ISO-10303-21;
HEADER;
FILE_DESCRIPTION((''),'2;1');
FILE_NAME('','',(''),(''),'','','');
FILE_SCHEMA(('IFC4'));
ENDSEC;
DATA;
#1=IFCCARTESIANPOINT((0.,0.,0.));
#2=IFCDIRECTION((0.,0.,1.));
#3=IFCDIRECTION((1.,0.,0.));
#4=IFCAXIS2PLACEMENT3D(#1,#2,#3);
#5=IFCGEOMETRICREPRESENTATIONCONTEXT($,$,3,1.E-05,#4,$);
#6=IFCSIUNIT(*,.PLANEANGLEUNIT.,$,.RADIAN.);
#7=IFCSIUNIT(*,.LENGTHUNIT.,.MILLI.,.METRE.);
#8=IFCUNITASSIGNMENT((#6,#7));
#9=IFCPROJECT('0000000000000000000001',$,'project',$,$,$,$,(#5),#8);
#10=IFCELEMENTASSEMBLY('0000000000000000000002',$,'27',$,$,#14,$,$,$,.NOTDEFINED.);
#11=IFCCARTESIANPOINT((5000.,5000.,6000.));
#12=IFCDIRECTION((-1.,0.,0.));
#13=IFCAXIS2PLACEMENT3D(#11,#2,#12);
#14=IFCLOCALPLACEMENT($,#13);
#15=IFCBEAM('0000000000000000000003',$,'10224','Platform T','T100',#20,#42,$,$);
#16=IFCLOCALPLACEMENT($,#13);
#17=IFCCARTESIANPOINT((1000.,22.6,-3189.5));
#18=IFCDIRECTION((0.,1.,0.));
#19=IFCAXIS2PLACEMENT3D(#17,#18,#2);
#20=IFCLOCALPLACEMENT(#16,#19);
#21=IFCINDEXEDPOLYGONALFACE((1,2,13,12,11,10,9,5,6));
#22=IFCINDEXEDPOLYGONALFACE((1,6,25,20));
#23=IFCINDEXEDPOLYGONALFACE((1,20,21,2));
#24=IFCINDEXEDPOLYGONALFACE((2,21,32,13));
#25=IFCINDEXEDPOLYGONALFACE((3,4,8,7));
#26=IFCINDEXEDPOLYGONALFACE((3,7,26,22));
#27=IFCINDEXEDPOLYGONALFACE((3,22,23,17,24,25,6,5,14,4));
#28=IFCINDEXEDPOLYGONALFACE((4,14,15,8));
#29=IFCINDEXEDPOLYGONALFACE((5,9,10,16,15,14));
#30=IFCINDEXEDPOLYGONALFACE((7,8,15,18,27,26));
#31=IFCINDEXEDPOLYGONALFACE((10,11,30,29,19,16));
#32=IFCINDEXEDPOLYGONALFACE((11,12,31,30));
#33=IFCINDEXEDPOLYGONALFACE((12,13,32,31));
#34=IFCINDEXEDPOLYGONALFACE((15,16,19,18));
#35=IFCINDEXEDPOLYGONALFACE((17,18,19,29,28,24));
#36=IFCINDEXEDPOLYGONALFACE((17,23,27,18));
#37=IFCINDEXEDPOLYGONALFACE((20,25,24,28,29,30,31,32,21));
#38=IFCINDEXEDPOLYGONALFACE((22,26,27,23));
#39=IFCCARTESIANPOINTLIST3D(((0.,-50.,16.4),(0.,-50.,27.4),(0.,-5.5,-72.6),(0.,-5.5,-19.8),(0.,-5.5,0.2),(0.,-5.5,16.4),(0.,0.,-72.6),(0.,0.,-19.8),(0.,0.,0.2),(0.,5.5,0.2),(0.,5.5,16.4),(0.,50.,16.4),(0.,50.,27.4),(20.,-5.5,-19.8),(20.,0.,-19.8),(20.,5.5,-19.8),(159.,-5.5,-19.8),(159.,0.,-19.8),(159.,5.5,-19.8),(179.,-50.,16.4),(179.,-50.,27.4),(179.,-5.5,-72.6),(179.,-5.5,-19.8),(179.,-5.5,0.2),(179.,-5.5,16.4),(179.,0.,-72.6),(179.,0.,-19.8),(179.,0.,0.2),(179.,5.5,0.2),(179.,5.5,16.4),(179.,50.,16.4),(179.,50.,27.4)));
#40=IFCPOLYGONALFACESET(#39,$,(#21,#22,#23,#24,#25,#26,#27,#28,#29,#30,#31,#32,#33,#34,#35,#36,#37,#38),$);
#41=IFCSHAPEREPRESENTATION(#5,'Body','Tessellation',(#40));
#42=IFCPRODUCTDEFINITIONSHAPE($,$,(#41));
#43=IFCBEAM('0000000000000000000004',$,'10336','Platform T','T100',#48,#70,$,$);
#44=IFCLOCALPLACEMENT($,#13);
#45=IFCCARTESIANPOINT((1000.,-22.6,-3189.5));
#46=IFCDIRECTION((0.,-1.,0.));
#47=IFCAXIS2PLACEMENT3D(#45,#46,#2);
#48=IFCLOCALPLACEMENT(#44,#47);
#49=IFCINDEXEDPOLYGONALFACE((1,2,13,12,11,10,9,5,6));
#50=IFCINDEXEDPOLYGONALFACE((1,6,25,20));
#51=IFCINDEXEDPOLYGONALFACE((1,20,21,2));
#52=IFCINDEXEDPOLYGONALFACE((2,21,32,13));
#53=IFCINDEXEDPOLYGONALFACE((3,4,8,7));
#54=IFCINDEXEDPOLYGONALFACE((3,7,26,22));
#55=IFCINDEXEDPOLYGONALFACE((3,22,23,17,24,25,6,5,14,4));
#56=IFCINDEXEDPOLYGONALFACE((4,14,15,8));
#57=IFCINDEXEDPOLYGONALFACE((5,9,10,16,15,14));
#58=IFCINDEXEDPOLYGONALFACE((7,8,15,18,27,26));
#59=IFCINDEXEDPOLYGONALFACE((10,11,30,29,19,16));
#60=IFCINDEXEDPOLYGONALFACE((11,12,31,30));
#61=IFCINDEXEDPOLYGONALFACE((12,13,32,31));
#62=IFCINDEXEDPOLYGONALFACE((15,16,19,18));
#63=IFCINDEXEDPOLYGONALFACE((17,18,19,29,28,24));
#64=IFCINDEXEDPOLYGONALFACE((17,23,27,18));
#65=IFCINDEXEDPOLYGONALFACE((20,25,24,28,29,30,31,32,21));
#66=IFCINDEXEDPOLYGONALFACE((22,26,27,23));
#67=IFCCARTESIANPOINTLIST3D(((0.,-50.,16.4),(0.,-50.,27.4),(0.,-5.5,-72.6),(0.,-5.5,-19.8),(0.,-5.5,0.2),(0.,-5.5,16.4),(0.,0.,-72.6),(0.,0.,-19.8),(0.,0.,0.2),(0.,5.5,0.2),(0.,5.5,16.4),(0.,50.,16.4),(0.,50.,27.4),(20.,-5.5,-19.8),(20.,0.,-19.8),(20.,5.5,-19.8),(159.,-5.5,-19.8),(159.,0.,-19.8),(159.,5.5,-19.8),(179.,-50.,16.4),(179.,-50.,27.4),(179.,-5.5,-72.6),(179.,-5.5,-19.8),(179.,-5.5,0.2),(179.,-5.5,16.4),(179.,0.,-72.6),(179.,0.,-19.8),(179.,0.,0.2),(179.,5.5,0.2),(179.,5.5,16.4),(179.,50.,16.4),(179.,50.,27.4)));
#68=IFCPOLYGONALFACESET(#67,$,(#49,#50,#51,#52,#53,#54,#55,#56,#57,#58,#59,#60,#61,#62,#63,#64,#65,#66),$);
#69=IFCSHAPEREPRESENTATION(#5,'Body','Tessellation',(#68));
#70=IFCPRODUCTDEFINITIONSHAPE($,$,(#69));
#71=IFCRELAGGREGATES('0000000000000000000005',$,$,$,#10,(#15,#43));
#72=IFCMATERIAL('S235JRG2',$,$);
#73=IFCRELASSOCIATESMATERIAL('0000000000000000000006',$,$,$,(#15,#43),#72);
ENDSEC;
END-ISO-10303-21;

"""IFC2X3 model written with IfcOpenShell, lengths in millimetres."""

from ifc_helpers import new_model, si_unit, point, frame, origin_with_axes, place, context, project, polyline, line_curve, trimmed, segment, composite_curve, outline, extrude, material, element, aggregate, save


model = new_model("IFC2X3")

# Units and contexts
context_of_model = context(None, 3, precision=1e-05, world=origin_with_axes())
ifc_project = project(units=[si_unit("PLANEANGLEUNIT", "RADIAN"), si_unit("LENGTHUNIT", "METRE", prefix="MILLI")], contexts=[context_of_model])

# Element assembly, beams, openings
assembly_1_placement = place(None, frame((5000.0, 5000.0, 6000.0), z_axis=(0.0, 0.0, 1.0), x_axis=(-1.0, 0.0, 0.0)))
assembly_1 = element("IfcElementAssembly", 1, at=assembly_1_placement, Name="27", PredefinedType="NOTDEFINED")
ifc_material = material(Name="S235JRG2")
placement_1 = place(None, frame((5000.0, 5000.0, 6000.0), z_axis=(0.0, 0.0, 1.0), x_axis=(-1.0, 0.0, 0.0)))
beam_1_placement = place(placement_1, frame((1000.0, 22.6, -3189.5), z_axis=(0.0, 1.0, 0.0), x_axis=(0.0, 0.0, 1.0)))
beam_1 = element("IfcBeam", 2, at=beam_1_placement, material=ifc_material, Name="10224", Description="Platform T", ObjectType="T100", context=context_of_model, shape_type="SweptSolid", body=[
    extrude(outline(polyline([(5.5, -72.6), (5.5, 16.4), (50.0, 16.4), (50.0, 27.4), (-50.0, 27.4), (-50.0, 16.4), (-5.5, 16.4), (-5.5, -72.6), (5.5, -72.6), (5.5, -72.6)])), frame((0.0, 0.0, 0.0), z_axis=(1.0, 0.0, 0.0), x_axis=(0.0, 1.0, 0.0)), (0.0, 0.0, 1.0), 179.0),
])
opening_1_placement = place(beam_1_placement, frame((179.0, 0.0, -72.6), z_axis=(0.0, 1.0, 0.0), x_axis=(0.0, 0.0, 1.0)))
element("IfcOpeningElement", 3, at=opening_1_placement, cuts=beam_1, ObjectType="Recess", context=context_of_model, shape_type="SweptSolid", body=[
    extrude(outline(composite_curve([segment(trimmed(line_curve((0.0, 0.0), (0.0, -1.0, 0.0), 179.0), [point((0.0, 0.0))], [point((0.0, -179.0))], True, "CARTESIAN"), True, "CONTINUOUS"), segment(trimmed(line_curve((0.0, -179.0), (1.0, 0.0, 0.0), 52.8), [point((0.0, -179.0))], [point((52.8, -179.0))], True, "CARTESIAN"), True, "CONTINUOUS"), segment(trimmed(line_curve((52.8, -179.0), (0.0, 1.0, 0.0), 179.0), [point((52.8, -179.0))], [point((52.8, 0.0))], True, "CARTESIAN"), True, "CONTINUOUS"), segment(trimmed(line_curve((52.8, 0.0), (-1.0, 0.0, 0.0), 52.8), [point((52.8, 0.0))], [point((0.0, 0.0))], True, "CARTESIAN"), True, "CONTINUOUS")], self_intersect=False)), origin_with_axes(), (0.0, 0.0, 1.0), 100.0),
])
opening_2_placement = place(beam_1_placement, frame((179.0, 0.0, -19.8), z_axis=(0.0, 1.0, 0.0), x_axis=(0.0, 0.0, 1.0)))
element("IfcOpeningElement", 4, at=opening_2_placement, cuts=beam_1, context=context_of_model, shape_type="SweptSolid", body=[
    extrude(outline(composite_curve([segment(trimmed(line_curve((0.0, 0.0), (1.0, 0.0, 0.0), 20.0), [point((0.0, 0.0))], [point((20.0, 0.0))], True, "CARTESIAN"), True, "CONTINUOUS"), segment(trimmed(line_curve((20.0, 0.0), (-0.707107, -0.707107, 0.0), 28.284271), [point((20.0, 0.0))], [point((0.0, -20.0))], True, "CARTESIAN"), True, "CONTINUOUS"), segment(trimmed(line_curve((0.0, -20.0), (0.0, 1.0, 0.0), 20.0), [point((0.0, -20.0))], [point((0.0, 0.0))], True, "CARTESIAN"), True, "CONTINUOUS")], self_intersect=False)), origin_with_axes(), (0.0, 0.0, 1.0), 100.0),
])
opening_3_placement = place(beam_1_placement, frame((179.0, 0.0, -19.8), z_axis=(0.0, -1.0, 0.0), x_axis=(0.0, 0.0, -1.0)))
element("IfcOpeningElement", 5, at=opening_3_placement, cuts=beam_1, context=context_of_model, shape_type="SweptSolid", body=[
    extrude(outline(composite_curve([segment(trimmed(line_curve((0.0, 0.0), (-1.0, 0.0, 0.0), 20.0), [point((0.0, 0.0))], [point((-20.0, 0.0))], True, "CARTESIAN"), True, "CONTINUOUS"), segment(trimmed(line_curve((-20.0, 0.0), (0.707107, -0.707107, 0.0), 28.284271), [point((-20.0, 0.0))], [point((0.0, -20.0))], True, "CARTESIAN"), True, "CONTINUOUS"), segment(trimmed(line_curve((0.0, -20.0), (0.0, 1.0, 0.0), 20.0), [point((0.0, -20.0))], [point((0.0, 0.0))], True, "CARTESIAN"), True, "CONTINUOUS")], self_intersect=False)), origin_with_axes(), (0.0, 0.0, 1.0), 100.0),
])
opening_4_placement = place(beam_1_placement, frame((0.0, 0.0, -19.8), z_axis=(0.0, -1.0, 0.0), x_axis=(0.0, 0.0, -1.0)))
element("IfcOpeningElement", 6, at=opening_4_placement, cuts=beam_1, context=context_of_model, shape_type="SweptSolid", body=[
    extrude(outline(composite_curve([segment(trimmed(line_curve((0.0, 0.0), (-1.0, 0.0, 0.0), 20.0), [point((0.0, 0.0))], [point((-20.0, 0.0))], True, "CARTESIAN"), True, "CONTINUOUS"), segment(trimmed(line_curve((-20.0, 0.0), (0.707107, 0.707107, 0.0), 28.284271), [point((-20.0, 0.0))], [point((0.0, 20.0))], True, "CARTESIAN"), True, "CONTINUOUS"), segment(trimmed(line_curve((0.0, 20.0), (0.0, -1.0, 0.0), 20.0), [point((0.0, 20.0))], [point((0.0, 0.0))], True, "CARTESIAN"), True, "CONTINUOUS")], self_intersect=False)), origin_with_axes(), (0.0, 0.0, 1.0), 100.0),
])
opening_5_placement = place(beam_1_placement, frame((0.0, 0.0, -19.8), z_axis=(0.0, 1.0, 0.0), x_axis=(0.0, 0.0, 1.0)))
element("IfcOpeningElement", 7, at=opening_5_placement, cuts=beam_1, context=context_of_model, shape_type="SweptSolid", body=[
    extrude(outline(composite_curve([segment(trimmed(line_curve((0.0, 0.0), (1.0, 0.0, 0.0), 20.0), [point((0.0, 0.0))], [point((20.0, 0.0))], True, "CARTESIAN"), True, "CONTINUOUS"), segment(trimmed(line_curve((20.0, 0.0), (-0.707107, 0.707107, 0.0), 28.284271), [point((20.0, 0.0))], [point((0.0, 20.0))], True, "CARTESIAN"), True, "CONTINUOUS"), segment(trimmed(line_curve((0.0, 20.0), (0.0, -1.0, 0.0), 20.0), [point((0.0, 20.0))], [point((0.0, 0.0))], True, "CARTESIAN"), True, "CONTINUOUS")], self_intersect=False)), origin_with_axes(), (0.0, 0.0, 1.0), 100.0),
])
placement_2 = place(None, frame((5000.0, 5000.0, 6000.0), z_axis=(0.0, 0.0, 1.0), x_axis=(-1.0, 0.0, 0.0)))
beam_2_placement = place(placement_2, frame((1000.0, -22.6, -3189.5), z_axis=(0.0, -1.0, 0.0), x_axis=(0.0, 0.0, 1.0)))
beam_2 = element("IfcBeam", 8, at=beam_2_placement, material=ifc_material, Name="10336", Description="Platform T", ObjectType="T100", context=context_of_model, shape_type="SweptSolid", body=[
    extrude(outline(polyline([(5.5, -72.6), (5.5, 16.4), (50.0, 16.4), (50.0, 27.4), (-50.0, 27.4), (-50.0, 16.4), (-5.5, 16.4), (-5.5, -72.6), (5.5, -72.6), (5.5, -72.6)])), frame((0.0, 0.0, 0.0), z_axis=(1.0, 0.0, 0.0), x_axis=(0.0, 1.0, 0.0)), (0.0, 0.0, 1.0), 179.0),
])
opening_6_placement = place(beam_2_placement, frame((179.0, 0.0, -72.6), z_axis=(0.0, 1.0, 0.0), x_axis=(0.0, 0.0, 1.0)))
element("IfcOpeningElement", 9, at=opening_6_placement, cuts=beam_2, ObjectType="Recess", context=context_of_model, shape_type="SweptSolid", body=[
    extrude(outline(composite_curve([segment(trimmed(line_curve((0.0, 0.0), (0.0, -1.0, 0.0), 179.0), [point((0.0, 0.0))], [point((0.0, -179.0))], True, "CARTESIAN"), True, "CONTINUOUS"), segment(trimmed(line_curve((0.0, -179.0), (1.0, 0.0, 0.0), 52.8), [point((0.0, -179.0))], [point((52.8, -179.0))], True, "CARTESIAN"), True, "CONTINUOUS"), segment(trimmed(line_curve((52.8, -179.0), (0.0, 1.0, 0.0), 179.0), [point((52.8, -179.0))], [point((52.8, 0.0))], True, "CARTESIAN"), True, "CONTINUOUS"), segment(trimmed(line_curve((52.8, 0.0), (-1.0, 0.0, 0.0), 52.8), [point((52.8, 0.0))], [point((0.0, 0.0))], True, "CARTESIAN"), True, "CONTINUOUS")], self_intersect=False)), origin_with_axes(), (0.0, 0.0, 1.0), 100.0),
])
opening_7_placement = place(beam_2_placement, frame((179.0, 0.0, -19.8), z_axis=(0.0, 1.0, 0.0), x_axis=(0.0, 0.0, 1.0)))
element("IfcOpeningElement", 10, at=opening_7_placement, cuts=beam_2, context=context_of_model, shape_type="SweptSolid", body=[
    extrude(outline(composite_curve([segment(trimmed(line_curve((0.0, 0.0), (1.0, 0.0, 0.0), 20.0), [point((0.0, 0.0))], [point((20.0, 0.0))], True, "CARTESIAN"), True, "CONTINUOUS"), segment(trimmed(line_curve((20.0, 0.0), (-0.707107, -0.707107, 0.0), 28.284271), [point((20.0, 0.0))], [point((0.0, -20.0))], True, "CARTESIAN"), True, "CONTINUOUS"), segment(trimmed(line_curve((0.0, -20.0), (0.0, 1.0, 0.0), 20.0), [point((0.0, -20.0))], [point((0.0, 0.0))], True, "CARTESIAN"), True, "CONTINUOUS")], self_intersect=False)), origin_with_axes(), (0.0, 0.0, 1.0), 100.0),
])
opening_8_placement = place(beam_2_placement, frame((179.0, 0.0, -19.8), z_axis=(0.0, -1.0, 0.0), x_axis=(0.0, 0.0, -1.0)))
element("IfcOpeningElement", 11, at=opening_8_placement, cuts=beam_2, context=context_of_model, shape_type="SweptSolid", body=[
    extrude(outline(composite_curve([segment(trimmed(line_curve((0.0, 0.0), (-1.0, 0.0, 0.0), 20.0), [point((0.0, 0.0))], [point((-20.0, 0.0))], True, "CARTESIAN"), True, "CONTINUOUS"), segment(trimmed(line_curve((-20.0, 0.0), (0.707107, -0.707107, 0.0), 28.284271), [point((-20.0, 0.0))], [point((0.0, -20.0))], True, "CARTESIAN"), True, "CONTINUOUS"), segment(trimmed(line_curve((0.0, -20.0), (0.0, 1.0, 0.0), 20.0), [point((0.0, -20.0))], [point((0.0, 0.0))], True, "CARTESIAN"), True, "CONTINUOUS")], self_intersect=False)), origin_with_axes(), (0.0, 0.0, 1.0), 100.0),
])
opening_9_placement = place(beam_2_placement, frame((0.0, 0.0, -19.8), z_axis=(0.0, -1.0, 0.0), x_axis=(0.0, 0.0, -1.0)))
element("IfcOpeningElement", 12, at=opening_9_placement, cuts=beam_2, context=context_of_model, shape_type="SweptSolid", body=[
    extrude(outline(composite_curve([segment(trimmed(line_curve((0.0, 0.0), (-1.0, 0.0, 0.0), 20.0), [point((0.0, 0.0))], [point((-20.0, 0.0))], True, "CARTESIAN"), True, "CONTINUOUS"), segment(trimmed(line_curve((-20.0, 0.0), (0.707107, 0.707107, 0.0), 28.284271), [point((-20.0, 0.0))], [point((0.0, 20.0))], True, "CARTESIAN"), True, "CONTINUOUS"), segment(trimmed(line_curve((0.0, 20.0), (0.0, -1.0, 0.0), 20.0), [point((0.0, 20.0))], [point((0.0, 0.0))], True, "CARTESIAN"), True, "CONTINUOUS")], self_intersect=False)), origin_with_axes(), (0.0, 0.0, 1.0), 100.0),
])
opening_10_placement = place(beam_2_placement, frame((0.0, 0.0, -19.8), z_axis=(0.0, 1.0, 0.0), x_axis=(0.0, 0.0, 1.0)))
element("IfcOpeningElement", 13, at=opening_10_placement, cuts=beam_2, context=context_of_model, shape_type="SweptSolid", body=[
    extrude(outline(composite_curve([segment(trimmed(line_curve((0.0, 0.0), (1.0, 0.0, 0.0), 20.0), [point((0.0, 0.0))], [point((20.0, 0.0))], True, "CARTESIAN"), True, "CONTINUOUS"), segment(trimmed(line_curve((20.0, 0.0), (-0.707107, 0.707107, 0.0), 28.284271), [point((20.0, 0.0))], [point((0.0, 20.0))], True, "CARTESIAN"), True, "CONTINUOUS"), segment(trimmed(line_curve((0.0, 20.0), (0.0, -1.0, 0.0), 20.0), [point((0.0, 20.0))], [point((0.0, 0.0))], True, "CARTESIAN"), True, "CONTINUOUS")], self_intersect=False)), origin_with_axes(), (0.0, 0.0, 1.0), 100.0),
])
aggregate(assembly_1, [beam_1, beam_2])

save(model, "model.ifc")
